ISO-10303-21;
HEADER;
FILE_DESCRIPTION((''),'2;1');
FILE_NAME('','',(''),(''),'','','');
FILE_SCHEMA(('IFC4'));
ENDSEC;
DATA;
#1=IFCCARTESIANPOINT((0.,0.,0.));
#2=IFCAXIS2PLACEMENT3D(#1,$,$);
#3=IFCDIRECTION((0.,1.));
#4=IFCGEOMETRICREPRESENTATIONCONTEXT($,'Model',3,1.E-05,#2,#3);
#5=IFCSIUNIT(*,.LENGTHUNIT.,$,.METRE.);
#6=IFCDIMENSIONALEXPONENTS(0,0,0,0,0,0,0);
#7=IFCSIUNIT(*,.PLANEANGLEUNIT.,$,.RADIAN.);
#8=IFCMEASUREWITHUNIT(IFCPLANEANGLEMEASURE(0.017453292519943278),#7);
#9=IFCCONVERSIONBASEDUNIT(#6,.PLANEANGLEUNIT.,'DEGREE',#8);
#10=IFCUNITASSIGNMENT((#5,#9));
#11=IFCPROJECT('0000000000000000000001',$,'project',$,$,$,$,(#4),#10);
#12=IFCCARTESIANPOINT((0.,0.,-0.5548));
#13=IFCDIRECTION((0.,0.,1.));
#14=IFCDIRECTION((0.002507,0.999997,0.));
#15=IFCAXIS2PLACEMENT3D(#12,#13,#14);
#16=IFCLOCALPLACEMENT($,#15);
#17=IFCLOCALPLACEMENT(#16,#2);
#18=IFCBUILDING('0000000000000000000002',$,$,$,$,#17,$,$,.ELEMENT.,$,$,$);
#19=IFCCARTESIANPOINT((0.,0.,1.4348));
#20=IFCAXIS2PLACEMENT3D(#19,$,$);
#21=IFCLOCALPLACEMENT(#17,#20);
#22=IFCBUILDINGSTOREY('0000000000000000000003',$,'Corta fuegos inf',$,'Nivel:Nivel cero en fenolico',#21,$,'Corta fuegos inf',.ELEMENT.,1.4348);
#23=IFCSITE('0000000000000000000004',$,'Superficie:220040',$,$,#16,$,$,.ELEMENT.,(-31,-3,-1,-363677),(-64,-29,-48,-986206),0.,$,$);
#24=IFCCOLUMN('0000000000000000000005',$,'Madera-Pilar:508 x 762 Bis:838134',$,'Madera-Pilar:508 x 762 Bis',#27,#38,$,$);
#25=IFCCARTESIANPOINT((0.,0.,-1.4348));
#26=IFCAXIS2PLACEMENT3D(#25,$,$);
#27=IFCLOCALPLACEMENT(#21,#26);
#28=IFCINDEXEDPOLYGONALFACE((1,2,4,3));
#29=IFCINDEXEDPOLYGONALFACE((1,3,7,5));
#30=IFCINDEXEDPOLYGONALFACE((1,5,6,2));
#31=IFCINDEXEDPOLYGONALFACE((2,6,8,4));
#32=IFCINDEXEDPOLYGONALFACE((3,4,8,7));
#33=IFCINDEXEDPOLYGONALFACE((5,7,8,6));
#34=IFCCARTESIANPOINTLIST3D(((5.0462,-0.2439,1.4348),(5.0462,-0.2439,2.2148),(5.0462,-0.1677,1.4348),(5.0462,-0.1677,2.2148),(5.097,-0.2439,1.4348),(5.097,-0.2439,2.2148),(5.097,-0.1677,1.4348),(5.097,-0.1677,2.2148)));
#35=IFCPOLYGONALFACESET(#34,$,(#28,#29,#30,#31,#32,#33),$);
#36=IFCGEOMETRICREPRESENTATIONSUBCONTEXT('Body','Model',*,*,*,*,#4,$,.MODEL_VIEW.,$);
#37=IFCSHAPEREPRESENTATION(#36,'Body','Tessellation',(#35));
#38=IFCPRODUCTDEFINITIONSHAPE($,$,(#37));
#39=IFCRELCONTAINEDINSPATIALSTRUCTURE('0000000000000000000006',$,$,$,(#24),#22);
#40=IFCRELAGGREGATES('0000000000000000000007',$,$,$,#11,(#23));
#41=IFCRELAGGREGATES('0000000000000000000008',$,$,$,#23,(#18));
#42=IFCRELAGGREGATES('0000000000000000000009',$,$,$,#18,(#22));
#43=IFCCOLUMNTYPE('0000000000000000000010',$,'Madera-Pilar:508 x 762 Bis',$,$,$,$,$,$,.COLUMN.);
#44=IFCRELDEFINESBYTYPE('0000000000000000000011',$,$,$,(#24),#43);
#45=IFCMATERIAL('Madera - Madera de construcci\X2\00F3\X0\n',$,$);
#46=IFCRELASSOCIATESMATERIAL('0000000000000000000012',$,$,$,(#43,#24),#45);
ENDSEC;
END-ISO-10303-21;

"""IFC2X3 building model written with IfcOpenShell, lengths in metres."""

from ifc_helpers import new_model, entity, si_unit, converted_unit, direction, frame, frame_2d, origin, place, context, subcontext, project, spatial, rectangle, extrude, source, transform, mapped, material, type_object, type_shapes, element, save


model = new_model("IFC2X3")

# Units and contexts
model_context = context("Model", 3, precision=1e-05, world=origin(), true_north=direction((0.0, 1.0)))
body_context = subcontext(model_context, "Body", "Model", "MODEL_VIEW")
ifc_project = project(units=[si_unit("LENGTHUNIT", "METRE"), converted_unit("PLANEANGLEUNIT", "DEGREE", entity("IfcPlaneAngleMeasure", 0.017453292519943278), si_unit("PLANEANGLEUNIT", "RADIAN"), dimensions=[0, 0, 0, 0, 0, 0, 0])], contexts=[model_context])

# Site, building, storey
site_placement = place(None, frame((0.0, 0.0, -0.5548), z_axis=(0.0, 0.0, 1.0), x_axis=(0.002507, 0.999997, 0.0)))
site = spatial("IfcSite", under=ifc_project, at=site_placement, Name="Superficie:220040", CompositionType="ELEMENT", RefLatitude=(-31, -3, -1, -363677), RefLongitude=(-64, -29, -48, -986206), RefElevation=0.0)
building_placement = place(site_placement, origin())
building = spatial("IfcBuilding", under=site, at=building_placement, CompositionType="ELEMENT")
storey_placement = place(building_placement, frame((0.0, 0.0, 1.4348)))
storey = spatial("IfcBuildingStorey", under=building, at=storey_placement, Name="Corta fuegos inf", ObjectType="Nivel:Nivel cero en fenolico", LongName="Corta fuegos inf", CompositionType="ELEMENT", Elevation=1.4348)

# Column
ifc_material = material(Name="Madera - Madera de construcción")
column_type_1 = type_object("IfcColumnType", Name="Madera-Pilar:508 x 762 Bis", PredefinedType="COLUMN", material=ifc_material)
shared_shape_1 = source(origin(), body_context, "Body", "SweptSolid", [
    extrude(rectangle(XDim=0.0508, YDim=0.0762, at=frame_2d((0.0, 0.0), x_axis=(1.0, 0.0))), frame((5.0716, -0.2058, 1.4348), z_axis=(0.0, 0.0, 1.0), x_axis=(-1.0, 0.0, 0.0)), (0.0, 0.0, 1.0), 0.78),
])
type_shapes(column_type_1, [shared_shape_1])
column_1_placement = place(storey_placement, frame((0.0, 0.0, -1.4348)))
element("IfcColumn", 1, at=column_1_placement, inside=storey, type_object=column_type_1, material=ifc_material, Name="Madera-Pilar:508 x 762 Bis:838134", ObjectType="Madera-Pilar:508 x 762 Bis", context=body_context, shape_type="MappedRepresentation", body=[
    mapped(shared_shape_1, transform((0.0, 0.0, 0.0), scale=1.0)),
])

save(model, "model.ifc")
